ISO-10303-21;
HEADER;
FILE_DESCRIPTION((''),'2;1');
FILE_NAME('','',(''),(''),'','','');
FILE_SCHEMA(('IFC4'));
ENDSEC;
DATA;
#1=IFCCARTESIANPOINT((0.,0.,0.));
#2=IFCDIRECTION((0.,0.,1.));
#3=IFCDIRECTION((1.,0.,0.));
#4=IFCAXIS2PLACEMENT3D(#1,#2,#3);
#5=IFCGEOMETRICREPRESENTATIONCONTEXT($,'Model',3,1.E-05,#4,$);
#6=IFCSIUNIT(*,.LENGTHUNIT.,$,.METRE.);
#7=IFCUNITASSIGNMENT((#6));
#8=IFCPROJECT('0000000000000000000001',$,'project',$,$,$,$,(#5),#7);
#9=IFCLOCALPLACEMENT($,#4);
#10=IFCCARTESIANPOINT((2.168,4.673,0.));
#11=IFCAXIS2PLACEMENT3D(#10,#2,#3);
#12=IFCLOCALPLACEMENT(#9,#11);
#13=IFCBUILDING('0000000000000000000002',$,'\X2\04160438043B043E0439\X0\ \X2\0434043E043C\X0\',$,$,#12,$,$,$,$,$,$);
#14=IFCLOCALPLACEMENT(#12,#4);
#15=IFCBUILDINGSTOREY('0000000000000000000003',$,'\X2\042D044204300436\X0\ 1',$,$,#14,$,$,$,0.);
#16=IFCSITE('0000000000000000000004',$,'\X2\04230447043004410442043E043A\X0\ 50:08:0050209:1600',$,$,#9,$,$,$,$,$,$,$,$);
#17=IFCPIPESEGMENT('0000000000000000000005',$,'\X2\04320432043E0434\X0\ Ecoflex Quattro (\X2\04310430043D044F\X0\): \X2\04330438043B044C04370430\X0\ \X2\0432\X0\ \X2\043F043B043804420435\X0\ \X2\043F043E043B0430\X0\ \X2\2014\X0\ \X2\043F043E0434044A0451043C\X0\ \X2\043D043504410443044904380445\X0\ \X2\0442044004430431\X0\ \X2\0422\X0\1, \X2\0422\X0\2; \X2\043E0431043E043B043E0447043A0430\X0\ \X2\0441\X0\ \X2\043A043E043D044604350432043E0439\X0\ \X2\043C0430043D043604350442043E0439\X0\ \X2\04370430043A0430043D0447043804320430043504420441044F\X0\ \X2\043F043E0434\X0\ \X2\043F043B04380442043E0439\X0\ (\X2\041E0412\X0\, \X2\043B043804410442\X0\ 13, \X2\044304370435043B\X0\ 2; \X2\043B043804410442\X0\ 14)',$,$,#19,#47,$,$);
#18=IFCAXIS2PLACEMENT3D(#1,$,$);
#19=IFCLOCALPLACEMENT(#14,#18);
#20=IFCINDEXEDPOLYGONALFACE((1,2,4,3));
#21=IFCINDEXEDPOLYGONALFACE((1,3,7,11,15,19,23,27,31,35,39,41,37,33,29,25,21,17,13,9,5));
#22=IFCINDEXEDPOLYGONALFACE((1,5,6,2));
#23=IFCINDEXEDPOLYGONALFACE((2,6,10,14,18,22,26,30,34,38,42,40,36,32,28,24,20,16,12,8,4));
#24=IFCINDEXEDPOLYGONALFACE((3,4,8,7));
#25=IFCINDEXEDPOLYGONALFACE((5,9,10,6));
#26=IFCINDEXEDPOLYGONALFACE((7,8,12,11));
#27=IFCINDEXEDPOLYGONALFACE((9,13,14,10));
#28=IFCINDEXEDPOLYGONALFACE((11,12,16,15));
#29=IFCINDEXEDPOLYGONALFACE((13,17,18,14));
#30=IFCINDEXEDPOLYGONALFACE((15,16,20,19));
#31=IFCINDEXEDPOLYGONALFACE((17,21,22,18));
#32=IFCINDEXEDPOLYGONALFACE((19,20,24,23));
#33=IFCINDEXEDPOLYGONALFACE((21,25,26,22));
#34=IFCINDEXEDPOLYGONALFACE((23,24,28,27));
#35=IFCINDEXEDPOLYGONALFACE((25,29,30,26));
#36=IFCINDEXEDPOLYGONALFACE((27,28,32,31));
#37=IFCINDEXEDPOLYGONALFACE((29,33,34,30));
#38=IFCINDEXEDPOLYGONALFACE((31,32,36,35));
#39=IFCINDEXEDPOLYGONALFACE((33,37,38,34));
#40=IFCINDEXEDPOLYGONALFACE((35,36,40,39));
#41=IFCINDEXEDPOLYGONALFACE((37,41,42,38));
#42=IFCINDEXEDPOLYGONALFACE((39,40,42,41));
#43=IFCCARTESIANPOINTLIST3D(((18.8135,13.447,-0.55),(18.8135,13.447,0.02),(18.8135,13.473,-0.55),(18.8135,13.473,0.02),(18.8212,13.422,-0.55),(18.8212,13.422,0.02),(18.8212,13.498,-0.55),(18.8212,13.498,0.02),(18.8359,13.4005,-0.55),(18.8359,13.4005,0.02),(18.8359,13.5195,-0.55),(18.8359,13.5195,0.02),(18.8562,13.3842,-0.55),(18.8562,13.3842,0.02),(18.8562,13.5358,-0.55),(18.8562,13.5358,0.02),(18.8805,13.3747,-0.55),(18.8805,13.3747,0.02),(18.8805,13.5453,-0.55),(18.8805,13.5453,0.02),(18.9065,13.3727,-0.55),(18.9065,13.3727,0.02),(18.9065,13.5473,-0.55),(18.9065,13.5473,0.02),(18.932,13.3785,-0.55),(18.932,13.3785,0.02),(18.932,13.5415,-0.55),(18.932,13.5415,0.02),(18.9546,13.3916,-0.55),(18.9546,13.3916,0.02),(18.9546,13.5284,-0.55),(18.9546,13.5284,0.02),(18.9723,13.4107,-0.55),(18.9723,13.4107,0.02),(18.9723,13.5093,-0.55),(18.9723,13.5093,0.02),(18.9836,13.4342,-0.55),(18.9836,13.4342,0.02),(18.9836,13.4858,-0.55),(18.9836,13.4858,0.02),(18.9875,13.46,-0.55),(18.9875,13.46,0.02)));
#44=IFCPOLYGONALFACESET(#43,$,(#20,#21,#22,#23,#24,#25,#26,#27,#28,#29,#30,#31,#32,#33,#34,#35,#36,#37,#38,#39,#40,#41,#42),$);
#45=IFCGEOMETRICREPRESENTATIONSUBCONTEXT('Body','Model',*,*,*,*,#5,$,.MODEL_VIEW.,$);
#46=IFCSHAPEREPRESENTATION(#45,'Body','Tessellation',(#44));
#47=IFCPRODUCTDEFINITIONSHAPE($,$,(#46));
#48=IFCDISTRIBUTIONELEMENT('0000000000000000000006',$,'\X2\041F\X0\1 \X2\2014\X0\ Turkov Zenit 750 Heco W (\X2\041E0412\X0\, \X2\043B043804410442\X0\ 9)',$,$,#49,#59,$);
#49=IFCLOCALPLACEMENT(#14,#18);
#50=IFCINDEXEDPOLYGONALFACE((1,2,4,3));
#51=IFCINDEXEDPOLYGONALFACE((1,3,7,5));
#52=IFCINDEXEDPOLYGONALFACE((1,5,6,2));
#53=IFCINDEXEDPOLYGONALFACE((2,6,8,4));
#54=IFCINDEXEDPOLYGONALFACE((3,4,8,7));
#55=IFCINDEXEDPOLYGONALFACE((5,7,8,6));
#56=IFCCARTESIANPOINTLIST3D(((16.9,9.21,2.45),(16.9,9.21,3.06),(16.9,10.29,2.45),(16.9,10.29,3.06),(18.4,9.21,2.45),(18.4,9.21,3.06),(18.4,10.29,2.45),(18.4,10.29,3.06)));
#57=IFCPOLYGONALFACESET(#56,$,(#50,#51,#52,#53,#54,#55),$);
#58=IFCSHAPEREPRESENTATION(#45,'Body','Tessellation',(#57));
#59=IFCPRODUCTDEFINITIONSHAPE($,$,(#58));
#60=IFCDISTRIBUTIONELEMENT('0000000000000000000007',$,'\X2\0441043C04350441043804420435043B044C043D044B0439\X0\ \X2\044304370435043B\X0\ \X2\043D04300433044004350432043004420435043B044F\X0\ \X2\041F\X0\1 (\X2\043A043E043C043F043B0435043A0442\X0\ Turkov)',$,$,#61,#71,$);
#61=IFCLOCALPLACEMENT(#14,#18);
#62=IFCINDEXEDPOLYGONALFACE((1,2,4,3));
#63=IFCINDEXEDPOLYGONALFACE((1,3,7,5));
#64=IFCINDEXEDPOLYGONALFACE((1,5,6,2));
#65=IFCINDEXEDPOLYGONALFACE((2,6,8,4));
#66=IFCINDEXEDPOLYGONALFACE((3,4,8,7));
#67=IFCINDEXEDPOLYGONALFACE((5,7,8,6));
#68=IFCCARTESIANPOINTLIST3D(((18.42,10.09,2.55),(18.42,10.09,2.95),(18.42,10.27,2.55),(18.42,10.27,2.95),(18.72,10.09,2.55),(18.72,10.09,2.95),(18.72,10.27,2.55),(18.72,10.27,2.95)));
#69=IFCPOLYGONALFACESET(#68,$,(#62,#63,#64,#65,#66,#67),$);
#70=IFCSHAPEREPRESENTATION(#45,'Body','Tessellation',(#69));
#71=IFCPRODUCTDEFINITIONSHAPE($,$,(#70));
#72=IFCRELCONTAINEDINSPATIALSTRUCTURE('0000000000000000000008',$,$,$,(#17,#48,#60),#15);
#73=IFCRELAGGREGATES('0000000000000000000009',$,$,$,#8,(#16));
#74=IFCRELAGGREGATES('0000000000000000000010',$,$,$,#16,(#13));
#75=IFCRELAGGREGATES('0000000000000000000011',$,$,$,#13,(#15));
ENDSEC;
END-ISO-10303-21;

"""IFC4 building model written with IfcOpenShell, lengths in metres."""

from ifc_helpers import new_model, si_unit, frame, frame_2d, origin_with_axes, origin_2d, place, context, subcontext, project, spatial, rectangle, circle, extrude, element, save


model = new_model("IFC4")

# Units and contexts
model_context = context("Model", 3, precision=1e-05, world=origin_with_axes())
body_context = subcontext(model_context, "Body", "Model", "MODEL_VIEW")
ifc_project = project(units=[si_unit("LENGTHUNIT", "METRE")], contexts=[model_context])

# Site, building, storey
site_placement = place(None, origin_with_axes())
site = spatial("IfcSite", under=ifc_project, at=site_placement, Name="Участок 50:08:0050209:1600")
building_placement = place(site_placement, frame((2.168, 4.673, 0.0), z_axis=(0.0, 0.0, 1.0), x_axis=(1.0, 0.0, 0.0)))
building = spatial("IfcBuilding", under=site, at=building_placement, Name="Жилой дом")
storey_placement = place(building_placement, origin_with_axes())
storey = spatial("IfcBuildingStorey", under=building, at=storey_placement, Name="Этаж 1", Elevation=0.0)

# Pipe segment
pipe_segment_placement = place(storey_placement, origin_with_axes())
element("IfcPipeSegment", 1, at=pipe_segment_placement, inside=storey, Name="ввод Ecoflex Quattro (баня): гильза в плите пола — подъём несущих труб Т1, Т2; оболочка с концевой манжетой заканчивается под плитой (ОВ, лист 13, узел 2; лист 14)", context=body_context, shape_type="SweptSolid", body=[
    extrude(circle(Radius=0.0875, at=origin_2d()), frame((18.9, 13.46, -0.55), z_axis=(0.0, 0.0, 1.0), x_axis=(1.0, 0.0, 0.0)), (0.0, 0.0, 1.0), 0.57),
])

# Distribution elements
distribution_element_1_placement = place(storey_placement, origin_with_axes())
element("IfcDistributionElement", 2, at=distribution_element_1_placement, inside=storey, Name="П1 — Turkov Zenit 750 Heco W (ОВ, лист 9)", context=body_context, shape_type="SweptSolid", body=[
    extrude(rectangle(XDim=1.5, YDim=1.08, at=frame_2d((0.75, 0.54))), frame((16.9, 9.21, 2.45), z_axis=(0.0, 0.0, 1.0), x_axis=(1.0, 0.0, 0.0)), (0.0, 0.0, 1.0), 0.61),
])
distribution_element_2_placement = place(storey_placement, origin_with_axes())
element("IfcDistributionElement", 3, at=distribution_element_2_placement, inside=storey, Name="смесительный узел нагревателя П1 (комплект Turkov)", context=body_context, shape_type="SweptSolid", body=[
    extrude(rectangle(XDim=0.3, YDim=0.18, at=frame_2d((0.15, 0.09))), frame((18.42, 10.09, 2.55), z_axis=(0.0, 0.0, 1.0), x_axis=(1.0, 0.0, 0.0)), (0.0, 0.0, 1.0), 0.4),
])

save(model, "model.ifc")
